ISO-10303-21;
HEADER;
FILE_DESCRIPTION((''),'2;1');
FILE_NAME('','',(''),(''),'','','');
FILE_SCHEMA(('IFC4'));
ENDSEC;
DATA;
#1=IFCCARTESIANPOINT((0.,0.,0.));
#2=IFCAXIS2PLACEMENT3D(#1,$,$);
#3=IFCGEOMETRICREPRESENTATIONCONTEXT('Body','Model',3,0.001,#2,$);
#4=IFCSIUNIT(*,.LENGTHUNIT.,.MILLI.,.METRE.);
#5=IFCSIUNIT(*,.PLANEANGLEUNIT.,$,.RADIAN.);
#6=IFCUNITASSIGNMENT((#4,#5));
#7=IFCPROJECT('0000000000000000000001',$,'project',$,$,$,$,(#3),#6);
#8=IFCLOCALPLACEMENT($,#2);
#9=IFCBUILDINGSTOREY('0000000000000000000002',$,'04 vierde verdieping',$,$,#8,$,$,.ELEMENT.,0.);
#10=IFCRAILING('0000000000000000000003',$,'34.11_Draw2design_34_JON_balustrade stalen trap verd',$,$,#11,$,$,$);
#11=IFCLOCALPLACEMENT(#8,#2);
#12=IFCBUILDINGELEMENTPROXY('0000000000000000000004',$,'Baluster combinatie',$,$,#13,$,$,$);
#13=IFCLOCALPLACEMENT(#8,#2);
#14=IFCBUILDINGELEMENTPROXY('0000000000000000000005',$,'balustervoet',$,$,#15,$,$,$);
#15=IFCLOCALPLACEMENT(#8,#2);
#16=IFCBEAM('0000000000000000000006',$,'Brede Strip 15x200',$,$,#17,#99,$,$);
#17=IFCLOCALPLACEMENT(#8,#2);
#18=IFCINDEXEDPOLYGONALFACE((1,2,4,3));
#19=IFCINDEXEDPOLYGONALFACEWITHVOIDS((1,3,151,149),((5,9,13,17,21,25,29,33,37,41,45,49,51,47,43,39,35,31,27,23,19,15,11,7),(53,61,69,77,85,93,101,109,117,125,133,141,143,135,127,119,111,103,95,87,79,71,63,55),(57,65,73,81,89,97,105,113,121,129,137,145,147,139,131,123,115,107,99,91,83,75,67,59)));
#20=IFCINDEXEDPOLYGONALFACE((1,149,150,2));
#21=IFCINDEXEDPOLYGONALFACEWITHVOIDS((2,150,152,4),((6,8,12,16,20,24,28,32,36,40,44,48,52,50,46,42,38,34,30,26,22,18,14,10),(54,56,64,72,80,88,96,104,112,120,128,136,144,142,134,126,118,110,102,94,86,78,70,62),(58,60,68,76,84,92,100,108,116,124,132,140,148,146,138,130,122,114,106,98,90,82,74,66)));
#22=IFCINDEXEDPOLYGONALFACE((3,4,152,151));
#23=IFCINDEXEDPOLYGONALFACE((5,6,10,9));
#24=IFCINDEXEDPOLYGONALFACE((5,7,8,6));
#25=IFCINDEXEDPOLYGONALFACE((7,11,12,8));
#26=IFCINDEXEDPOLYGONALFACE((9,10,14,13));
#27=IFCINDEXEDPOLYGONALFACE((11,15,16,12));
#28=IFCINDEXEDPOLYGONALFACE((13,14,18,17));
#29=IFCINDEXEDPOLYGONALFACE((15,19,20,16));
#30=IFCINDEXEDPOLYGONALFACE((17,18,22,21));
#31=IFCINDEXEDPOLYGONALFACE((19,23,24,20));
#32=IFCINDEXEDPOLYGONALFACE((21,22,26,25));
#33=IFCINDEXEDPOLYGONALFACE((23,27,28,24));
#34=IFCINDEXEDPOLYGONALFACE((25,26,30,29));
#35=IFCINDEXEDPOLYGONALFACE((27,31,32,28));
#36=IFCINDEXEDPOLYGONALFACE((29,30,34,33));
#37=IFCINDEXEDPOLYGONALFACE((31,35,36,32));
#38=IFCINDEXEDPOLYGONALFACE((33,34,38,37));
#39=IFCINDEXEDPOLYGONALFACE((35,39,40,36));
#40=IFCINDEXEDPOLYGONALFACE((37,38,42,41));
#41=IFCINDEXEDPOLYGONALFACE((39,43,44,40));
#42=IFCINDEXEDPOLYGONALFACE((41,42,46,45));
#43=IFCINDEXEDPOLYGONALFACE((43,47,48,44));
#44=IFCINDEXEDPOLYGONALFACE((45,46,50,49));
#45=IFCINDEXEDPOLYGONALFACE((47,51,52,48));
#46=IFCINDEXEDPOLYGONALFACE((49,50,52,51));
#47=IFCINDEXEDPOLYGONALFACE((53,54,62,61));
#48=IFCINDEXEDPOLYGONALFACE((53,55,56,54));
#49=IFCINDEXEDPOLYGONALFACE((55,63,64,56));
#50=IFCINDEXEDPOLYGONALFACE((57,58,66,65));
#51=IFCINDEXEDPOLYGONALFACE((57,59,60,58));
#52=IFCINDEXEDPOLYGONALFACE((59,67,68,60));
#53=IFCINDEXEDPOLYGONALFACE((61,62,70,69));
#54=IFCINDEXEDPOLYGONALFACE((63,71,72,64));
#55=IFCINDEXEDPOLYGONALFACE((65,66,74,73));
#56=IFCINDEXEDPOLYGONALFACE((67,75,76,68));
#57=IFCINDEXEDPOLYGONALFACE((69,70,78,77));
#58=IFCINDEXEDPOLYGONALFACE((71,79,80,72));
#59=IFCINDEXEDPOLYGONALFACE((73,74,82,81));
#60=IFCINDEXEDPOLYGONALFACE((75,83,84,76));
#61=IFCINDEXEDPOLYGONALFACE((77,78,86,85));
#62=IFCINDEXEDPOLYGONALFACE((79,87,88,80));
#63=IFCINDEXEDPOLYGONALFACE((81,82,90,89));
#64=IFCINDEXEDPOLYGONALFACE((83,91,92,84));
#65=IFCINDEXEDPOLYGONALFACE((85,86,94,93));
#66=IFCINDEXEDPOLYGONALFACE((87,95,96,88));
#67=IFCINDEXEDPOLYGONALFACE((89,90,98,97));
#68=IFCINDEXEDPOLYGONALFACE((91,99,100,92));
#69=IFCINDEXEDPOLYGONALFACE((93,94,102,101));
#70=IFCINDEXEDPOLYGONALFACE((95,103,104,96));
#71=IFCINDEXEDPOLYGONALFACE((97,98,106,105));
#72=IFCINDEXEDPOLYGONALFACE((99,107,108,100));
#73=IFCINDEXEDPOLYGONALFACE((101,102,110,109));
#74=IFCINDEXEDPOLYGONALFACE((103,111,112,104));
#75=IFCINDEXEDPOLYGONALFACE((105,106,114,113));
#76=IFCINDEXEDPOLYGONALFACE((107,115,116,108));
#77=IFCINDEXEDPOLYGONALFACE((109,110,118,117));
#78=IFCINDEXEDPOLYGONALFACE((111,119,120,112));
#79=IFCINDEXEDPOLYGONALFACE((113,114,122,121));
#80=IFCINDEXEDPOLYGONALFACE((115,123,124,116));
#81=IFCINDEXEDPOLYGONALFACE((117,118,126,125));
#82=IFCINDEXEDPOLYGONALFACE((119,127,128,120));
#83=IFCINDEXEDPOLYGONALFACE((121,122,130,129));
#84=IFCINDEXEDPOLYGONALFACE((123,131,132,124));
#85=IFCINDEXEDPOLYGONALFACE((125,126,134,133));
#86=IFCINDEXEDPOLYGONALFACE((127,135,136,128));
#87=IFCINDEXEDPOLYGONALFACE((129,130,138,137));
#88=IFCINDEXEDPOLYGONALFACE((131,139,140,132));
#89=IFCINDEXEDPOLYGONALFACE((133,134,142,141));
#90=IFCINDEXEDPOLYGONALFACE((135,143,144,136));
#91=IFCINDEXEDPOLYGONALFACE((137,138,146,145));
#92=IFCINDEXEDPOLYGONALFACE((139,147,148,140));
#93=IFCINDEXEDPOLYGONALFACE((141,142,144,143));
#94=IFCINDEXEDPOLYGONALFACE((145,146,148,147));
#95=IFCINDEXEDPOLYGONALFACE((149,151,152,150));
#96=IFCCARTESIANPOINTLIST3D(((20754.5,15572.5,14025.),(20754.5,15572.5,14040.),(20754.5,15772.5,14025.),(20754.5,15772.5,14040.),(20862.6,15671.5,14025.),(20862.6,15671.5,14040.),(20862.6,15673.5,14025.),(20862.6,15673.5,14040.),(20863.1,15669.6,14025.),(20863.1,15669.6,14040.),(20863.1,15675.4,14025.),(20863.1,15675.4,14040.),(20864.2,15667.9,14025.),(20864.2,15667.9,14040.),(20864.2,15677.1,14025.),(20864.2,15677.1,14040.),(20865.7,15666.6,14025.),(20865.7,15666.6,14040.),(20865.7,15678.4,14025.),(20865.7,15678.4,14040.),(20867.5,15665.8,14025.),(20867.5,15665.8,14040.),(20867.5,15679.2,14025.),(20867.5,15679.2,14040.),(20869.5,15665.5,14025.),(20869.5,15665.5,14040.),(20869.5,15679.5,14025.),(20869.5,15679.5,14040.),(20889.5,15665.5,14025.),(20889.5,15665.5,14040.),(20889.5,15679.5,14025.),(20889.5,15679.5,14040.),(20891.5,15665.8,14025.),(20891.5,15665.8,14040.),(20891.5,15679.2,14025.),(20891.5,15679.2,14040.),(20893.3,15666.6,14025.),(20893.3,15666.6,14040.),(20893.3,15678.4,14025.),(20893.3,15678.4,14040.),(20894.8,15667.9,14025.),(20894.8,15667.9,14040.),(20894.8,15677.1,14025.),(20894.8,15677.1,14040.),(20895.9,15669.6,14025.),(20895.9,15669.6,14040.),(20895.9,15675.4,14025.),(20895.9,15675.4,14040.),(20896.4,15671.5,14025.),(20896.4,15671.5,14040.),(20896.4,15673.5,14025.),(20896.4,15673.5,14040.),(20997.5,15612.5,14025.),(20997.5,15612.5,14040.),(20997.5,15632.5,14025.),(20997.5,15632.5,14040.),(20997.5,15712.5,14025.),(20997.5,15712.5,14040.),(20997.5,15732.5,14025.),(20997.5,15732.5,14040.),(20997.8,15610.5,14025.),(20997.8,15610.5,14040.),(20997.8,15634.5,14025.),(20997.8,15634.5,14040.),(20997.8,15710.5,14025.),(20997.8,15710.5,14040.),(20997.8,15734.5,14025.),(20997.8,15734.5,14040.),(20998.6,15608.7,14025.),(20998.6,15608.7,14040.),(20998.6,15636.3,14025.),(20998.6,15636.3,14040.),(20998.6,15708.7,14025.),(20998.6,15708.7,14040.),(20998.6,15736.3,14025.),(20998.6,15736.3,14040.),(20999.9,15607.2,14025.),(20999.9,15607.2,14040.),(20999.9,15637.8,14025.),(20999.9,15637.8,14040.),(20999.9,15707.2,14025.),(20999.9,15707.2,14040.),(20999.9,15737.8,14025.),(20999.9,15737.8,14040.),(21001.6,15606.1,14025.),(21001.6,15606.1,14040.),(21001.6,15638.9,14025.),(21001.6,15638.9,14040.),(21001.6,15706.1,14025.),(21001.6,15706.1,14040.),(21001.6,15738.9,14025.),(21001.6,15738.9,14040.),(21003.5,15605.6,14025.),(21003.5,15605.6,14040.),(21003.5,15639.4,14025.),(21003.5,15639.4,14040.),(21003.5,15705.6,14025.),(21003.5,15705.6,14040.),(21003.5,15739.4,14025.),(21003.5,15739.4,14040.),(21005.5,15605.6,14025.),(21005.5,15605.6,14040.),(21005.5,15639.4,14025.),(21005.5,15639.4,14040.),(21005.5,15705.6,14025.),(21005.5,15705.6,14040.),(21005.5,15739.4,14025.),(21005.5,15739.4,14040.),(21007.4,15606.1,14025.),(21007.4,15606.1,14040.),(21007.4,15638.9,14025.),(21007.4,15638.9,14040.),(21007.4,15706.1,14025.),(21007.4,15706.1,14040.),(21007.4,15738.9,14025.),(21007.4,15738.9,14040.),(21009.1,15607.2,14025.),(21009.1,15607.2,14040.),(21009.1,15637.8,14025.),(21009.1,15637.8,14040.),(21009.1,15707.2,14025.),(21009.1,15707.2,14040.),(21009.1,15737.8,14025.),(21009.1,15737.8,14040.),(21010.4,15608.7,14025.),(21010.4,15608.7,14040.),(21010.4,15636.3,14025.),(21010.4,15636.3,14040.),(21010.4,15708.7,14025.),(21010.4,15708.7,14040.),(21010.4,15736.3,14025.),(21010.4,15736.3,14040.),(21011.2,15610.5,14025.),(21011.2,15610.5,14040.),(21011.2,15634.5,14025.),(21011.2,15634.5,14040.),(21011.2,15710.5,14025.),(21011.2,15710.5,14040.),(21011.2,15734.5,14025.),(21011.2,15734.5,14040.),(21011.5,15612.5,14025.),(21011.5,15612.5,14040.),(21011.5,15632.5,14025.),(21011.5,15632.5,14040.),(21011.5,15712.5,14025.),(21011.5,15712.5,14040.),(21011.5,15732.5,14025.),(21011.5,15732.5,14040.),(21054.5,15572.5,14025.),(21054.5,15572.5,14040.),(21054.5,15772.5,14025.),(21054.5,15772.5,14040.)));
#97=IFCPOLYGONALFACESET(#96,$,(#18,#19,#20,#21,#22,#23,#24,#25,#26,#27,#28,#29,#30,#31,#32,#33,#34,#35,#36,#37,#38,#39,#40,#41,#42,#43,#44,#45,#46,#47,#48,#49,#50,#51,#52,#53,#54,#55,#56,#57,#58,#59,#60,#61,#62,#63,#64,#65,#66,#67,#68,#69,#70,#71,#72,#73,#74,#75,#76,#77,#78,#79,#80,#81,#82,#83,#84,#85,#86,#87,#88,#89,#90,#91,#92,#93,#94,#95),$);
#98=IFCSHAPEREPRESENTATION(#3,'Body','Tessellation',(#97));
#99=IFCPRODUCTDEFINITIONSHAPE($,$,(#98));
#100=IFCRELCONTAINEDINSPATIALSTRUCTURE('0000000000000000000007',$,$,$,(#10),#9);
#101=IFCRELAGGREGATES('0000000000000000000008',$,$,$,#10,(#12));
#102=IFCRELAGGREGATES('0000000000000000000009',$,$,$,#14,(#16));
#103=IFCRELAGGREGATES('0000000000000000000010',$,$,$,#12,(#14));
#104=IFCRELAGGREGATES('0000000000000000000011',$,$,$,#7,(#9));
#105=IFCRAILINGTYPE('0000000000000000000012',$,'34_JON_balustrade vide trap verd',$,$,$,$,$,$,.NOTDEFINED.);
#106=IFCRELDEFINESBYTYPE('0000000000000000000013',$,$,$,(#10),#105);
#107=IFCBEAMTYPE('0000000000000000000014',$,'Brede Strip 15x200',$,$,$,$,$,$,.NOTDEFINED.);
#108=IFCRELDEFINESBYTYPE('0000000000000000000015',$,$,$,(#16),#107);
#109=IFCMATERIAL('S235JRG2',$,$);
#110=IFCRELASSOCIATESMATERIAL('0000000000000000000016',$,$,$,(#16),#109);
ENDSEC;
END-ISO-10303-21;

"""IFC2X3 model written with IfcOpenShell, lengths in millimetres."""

from ifc_helpers import new_model, si_unit, point, frame, frame_2d, origin, origin_2d, place, context, project, spatial, circle_curve, line_curve, trimmed, segment, composite_curve, rectangle, outline, extrude, source, transform, mapped, material, type_object, element, aggregate, save


model = new_model("IFC2X3")

# Units and contexts
model_context = context("Model", 3, precision=0.001, world=origin(), identifier="Body")
ifc_project = project(units=[si_unit("LENGTHUNIT", "METRE", prefix="MILLI"), si_unit("PLANEANGLEUNIT", "RADIAN")], contexts=[model_context])

# Storey
storey_placement = place(None, origin())
storey = spatial("IfcBuildingStorey", under=ifc_project, at=storey_placement, Name="04 vierde verdieping", CompositionType="ELEMENT", Elevation=0.0)

# Shared definitions
ifc_material_1 = material(Name="S235JRG2")

# Railing, building element proxies, beam, openings
railing_type_1 = type_object("IfcRailingType", Name="34_JON_balustrade vide trap verd")
railing_1_placement = place(storey_placement, frame((-1939.6, -29817.1, 68383.6)))
railing_1 = element("IfcRailing", 1, at=railing_1_placement, inside=storey, type_object=railing_type_1, Name="34.11_Draw2design_34_JON_balustrade stalen trap verd")
proxy_1_placement = place(railing_1_placement, frame((22994.2, 44834.6, -54348.6), z_axis=(0.0, 0.0, 1.0), x_axis=(0.0, 1.0, 0.0)))
proxy_1 = element("IfcBuildingElementProxy", 2, at=proxy_1_placement, Name="Baluster combinatie")
aggregate(railing_1, [proxy_1])
proxy_2_placement = place(proxy_1_placement, frame((-44257.5, 21054.5, -49235.0), z_axis=(0.0, 0.0, 1.0), x_axis=(0.0, -1.0, 0.0)))
proxy_2 = element("IfcBuildingElementProxy", 3, at=proxy_2_placement, Name="balustervoet")
beam_type_1 = type_object("IfcBeamType", Name="Brede Strip 15x200")
shared_shape_1 = source(origin(), model_context, "Body", "SweptSolid", [
    extrude(rectangle(XDim=15.0, YDim=200.0, at=origin_2d()), origin(), (0.0, 0.0, -1.0), 300.0),
])
beam_1_placement = place(proxy_2_placement, frame((21054.5, 44912.5, 49232.5), z_axis=(1.0, 0.0, 0.0), x_axis=(0.0, 0.0, 1.0)))
beam_1 = element("IfcBeam", 4, at=beam_1_placement, type_object=beam_type_1, material=ifc_material_1, Name="Brede Strip 15x200", context=model_context, shape_type="MappedRepresentation", body=[
    mapped(shared_shape_1, transform((0.0, 0.0, 0.0), scale=1.0)),
])
opening_1_placement = place(beam_1_placement, frame((7.5, 0.0, -175.0), z_axis=(-1.0, 0.0, 0.0), x_axis=(0.0, 0.0, -1.0)))
element("IfcOpeningElement", 5, at=opening_1_placement, cuts=beam_1, ObjectType="Opening", context=model_context, shape_type="SweptSolid", body=[
    extrude(outline(composite_curve([segment(trimmed(circle_curve(frame_2d((10.0, 0.0), x_axis=(0.0, -1.0)), 7.0), [point((10.0, 7.0))], [point((10.0, -7.0))], False, "CARTESIAN"), True, "CONTINUOUS"), segment(trimmed(line_curve((10.0, -7.0), (-20.0, 0.0), 20.0), [point((10.0, -7.0))], [point((-10.0, -7.0))], True, "CARTESIAN"), True, "CONTINUOUS"), segment(trimmed(circle_curve(frame_2d((-10.0, 0.0), x_axis=(0.0, -1.0)), 7.0), [point((-10.0, -7.0))], [point((-10.0, 7.0))], False, "CARTESIAN"), True, "CONTINUOUS"), segment(trimmed(line_curve((-10.0, 7.0), (20.0, 0.0), 20.0), [point((-10.0, 7.0))], [point((10.0, 7.0))], True, "CARTESIAN"), True, "CONTINUOUS")], self_intersect=False)), origin(), (0.0, 0.0, 1.0), 15.0),
])
opening_2_placement = place(beam_1_placement, frame((7.5, -50.0, -50.0), z_axis=(-1.0, 0.0, 0.0), x_axis=(0.0, -1.0, 0.0)))
element("IfcOpeningElement", 6, at=opening_2_placement, cuts=beam_1, ObjectType="Opening", context=model_context, shape_type="SweptSolid", body=[
    extrude(outline(composite_curve([segment(trimmed(circle_curve(frame_2d((10.0, 0.0), x_axis=(0.0, -1.0)), 7.0), [point((10.0, 7.0))], [point((10.0, -7.0))], False, "CARTESIAN"), True, "CONTINUOUS"), segment(trimmed(line_curve((10.0, -7.0), (-20.0, 0.0), 20.0), [point((10.0, -7.0))], [point((-10.0, -7.0))], True, "CARTESIAN"), True, "CONTINUOUS"), segment(trimmed(circle_curve(frame_2d((-10.0, 0.0), x_axis=(0.0, -1.0)), 7.0), [point((-10.0, -7.0))], [point((-10.0, 7.0))], False, "CARTESIAN"), True, "CONTINUOUS"), segment(trimmed(line_curve((-10.0, 7.0), (20.0, 0.0), 20.0), [point((-10.0, 7.0))], [point((10.0, 7.0))], True, "CARTESIAN"), True, "CONTINUOUS")], self_intersect=False)), origin(), (0.0, 0.0, 1.0), 15.0),
])
opening_3_placement = place(beam_1_placement, frame((7.5, 50.0, -50.0), z_axis=(-1.0, 0.0, 0.0), x_axis=(0.0, -1.0, 0.0)))
element("IfcOpeningElement", 7, at=opening_3_placement, cuts=beam_1, ObjectType="Opening", context=model_context, shape_type="SweptSolid", body=[
    extrude(outline(composite_curve([segment(trimmed(circle_curve(frame_2d((10.0, 0.0), x_axis=(0.0, -1.0)), 7.0), [point((10.0, 7.0))], [point((10.0, -7.0))], False, "CARTESIAN"), True, "CONTINUOUS"), segment(trimmed(line_curve((10.0, -7.0), (-20.0, 0.0), 20.0), [point((10.0, -7.0))], [point((-10.0, -7.0))], True, "CARTESIAN"), True, "CONTINUOUS"), segment(trimmed(circle_curve(frame_2d((-10.0, 0.0), x_axis=(0.0, -1.0)), 7.0), [point((-10.0, -7.0))], [point((-10.0, 7.0))], False, "CARTESIAN"), True, "CONTINUOUS"), segment(trimmed(line_curve((-10.0, 7.0), (20.0, 0.0), 20.0), [point((-10.0, 7.0))], [point((10.0, 7.0))], True, "CARTESIAN"), True, "CONTINUOUS")], self_intersect=False)), origin(), (0.0, 0.0, 1.0), 15.0),
])
aggregate(proxy_2, [beam_1])
aggregate(proxy_1, [proxy_2])

save(model, "model.ifc")
